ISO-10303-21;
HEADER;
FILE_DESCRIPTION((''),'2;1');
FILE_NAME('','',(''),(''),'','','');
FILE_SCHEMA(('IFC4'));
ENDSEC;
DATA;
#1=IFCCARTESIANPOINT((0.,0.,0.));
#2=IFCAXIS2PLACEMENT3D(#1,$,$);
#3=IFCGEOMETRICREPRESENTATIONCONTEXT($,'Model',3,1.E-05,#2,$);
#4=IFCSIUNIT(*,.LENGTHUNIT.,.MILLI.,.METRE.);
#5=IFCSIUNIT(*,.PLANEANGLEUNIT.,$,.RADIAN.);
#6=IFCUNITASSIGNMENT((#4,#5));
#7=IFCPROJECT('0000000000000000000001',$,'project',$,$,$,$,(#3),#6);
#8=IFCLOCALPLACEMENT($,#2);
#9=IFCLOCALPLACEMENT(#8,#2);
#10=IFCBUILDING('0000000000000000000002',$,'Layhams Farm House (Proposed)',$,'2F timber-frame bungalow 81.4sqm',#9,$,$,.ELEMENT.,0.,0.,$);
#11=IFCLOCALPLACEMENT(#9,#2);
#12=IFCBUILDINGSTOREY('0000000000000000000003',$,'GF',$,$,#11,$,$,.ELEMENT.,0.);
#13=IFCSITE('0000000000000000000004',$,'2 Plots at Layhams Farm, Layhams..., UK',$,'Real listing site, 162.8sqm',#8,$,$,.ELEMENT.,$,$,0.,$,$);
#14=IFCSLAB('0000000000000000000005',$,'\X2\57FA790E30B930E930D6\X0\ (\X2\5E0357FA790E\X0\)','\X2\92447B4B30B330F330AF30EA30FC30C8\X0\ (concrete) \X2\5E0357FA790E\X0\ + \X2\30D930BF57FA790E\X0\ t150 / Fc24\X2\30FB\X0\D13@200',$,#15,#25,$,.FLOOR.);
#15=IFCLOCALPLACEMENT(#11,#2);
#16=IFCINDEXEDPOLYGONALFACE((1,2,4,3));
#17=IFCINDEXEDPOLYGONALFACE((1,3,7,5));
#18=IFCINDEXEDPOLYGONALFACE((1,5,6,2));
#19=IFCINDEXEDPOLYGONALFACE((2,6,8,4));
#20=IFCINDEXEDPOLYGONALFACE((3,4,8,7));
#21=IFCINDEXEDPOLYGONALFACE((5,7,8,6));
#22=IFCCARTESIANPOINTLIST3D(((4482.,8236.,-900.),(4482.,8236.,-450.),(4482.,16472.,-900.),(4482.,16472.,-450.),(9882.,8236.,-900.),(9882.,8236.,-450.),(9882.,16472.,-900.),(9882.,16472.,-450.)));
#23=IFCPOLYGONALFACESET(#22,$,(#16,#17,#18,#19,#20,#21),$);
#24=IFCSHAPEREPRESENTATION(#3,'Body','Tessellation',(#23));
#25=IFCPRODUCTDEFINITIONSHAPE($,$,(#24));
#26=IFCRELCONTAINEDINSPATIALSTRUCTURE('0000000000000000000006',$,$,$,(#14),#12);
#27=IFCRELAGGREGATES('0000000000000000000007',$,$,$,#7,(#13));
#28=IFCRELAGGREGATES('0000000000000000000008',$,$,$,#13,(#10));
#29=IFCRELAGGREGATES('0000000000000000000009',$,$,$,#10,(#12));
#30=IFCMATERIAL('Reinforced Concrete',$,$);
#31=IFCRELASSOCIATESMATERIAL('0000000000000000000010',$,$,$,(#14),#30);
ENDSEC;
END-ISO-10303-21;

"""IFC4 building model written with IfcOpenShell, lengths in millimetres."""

from ifc_helpers import new_model, si_unit, frame, frame_2d, origin, place, context, project, spatial, rectangle, extrude, material, element, save


model = new_model("IFC4")

# Units and contexts
model_context = context("Model", 3, precision=1e-05, world=origin())
ifc_project = project(units=[si_unit("LENGTHUNIT", "METRE", prefix="MILLI"), si_unit("PLANEANGLEUNIT", "RADIAN")], contexts=[model_context])

# Site, building, storey
site_placement = place(None, origin())
site = spatial("IfcSite", under=ifc_project, at=site_placement, Name="2 Plots at Layhams Farm, Layhams..., UK", ObjectType="Real listing site, 162.8sqm", CompositionType="ELEMENT", RefElevation=0.0)
building_placement = place(site_placement, origin())
building = spatial("IfcBuilding", under=site, at=building_placement, Name="Layhams Farm House (Proposed)", ObjectType="2F timber-frame bungalow 81.4sqm", CompositionType="ELEMENT", ElevationOfRefHeight=0.0, ElevationOfTerrain=0.0)
storey_placement = place(building_placement, origin())
storey = spatial("IfcBuildingStorey", under=building, at=storey_placement, Name="GF", CompositionType="ELEMENT", Elevation=0.0)

# Slab
ifc_material_1 = material(Name="Reinforced Concrete")
slab_1_placement = place(storey_placement, frame((2241.0, 4118.0, -450.0)))
element("IfcSlab", 1, at=slab_1_placement, inside=storey, material=ifc_material_1, Name="基礎スラブ (布基礎)", Description="鉄筋コンクリート (concrete) 布基礎 + ベタ基礎 t150 / Fc24・D13@200", PredefinedType="FLOOR", context=model_context, shape_type="SweptSolid", body=[
    extrude(rectangle(XDim=5400.0, YDim=8236.0, at=frame_2d((2700.0, 4118.0))), frame((2241.0, 4118.0, -450.0)), (0.0, 0.0, 1.0), 450.0),
])

save(model, "model.ifc")
